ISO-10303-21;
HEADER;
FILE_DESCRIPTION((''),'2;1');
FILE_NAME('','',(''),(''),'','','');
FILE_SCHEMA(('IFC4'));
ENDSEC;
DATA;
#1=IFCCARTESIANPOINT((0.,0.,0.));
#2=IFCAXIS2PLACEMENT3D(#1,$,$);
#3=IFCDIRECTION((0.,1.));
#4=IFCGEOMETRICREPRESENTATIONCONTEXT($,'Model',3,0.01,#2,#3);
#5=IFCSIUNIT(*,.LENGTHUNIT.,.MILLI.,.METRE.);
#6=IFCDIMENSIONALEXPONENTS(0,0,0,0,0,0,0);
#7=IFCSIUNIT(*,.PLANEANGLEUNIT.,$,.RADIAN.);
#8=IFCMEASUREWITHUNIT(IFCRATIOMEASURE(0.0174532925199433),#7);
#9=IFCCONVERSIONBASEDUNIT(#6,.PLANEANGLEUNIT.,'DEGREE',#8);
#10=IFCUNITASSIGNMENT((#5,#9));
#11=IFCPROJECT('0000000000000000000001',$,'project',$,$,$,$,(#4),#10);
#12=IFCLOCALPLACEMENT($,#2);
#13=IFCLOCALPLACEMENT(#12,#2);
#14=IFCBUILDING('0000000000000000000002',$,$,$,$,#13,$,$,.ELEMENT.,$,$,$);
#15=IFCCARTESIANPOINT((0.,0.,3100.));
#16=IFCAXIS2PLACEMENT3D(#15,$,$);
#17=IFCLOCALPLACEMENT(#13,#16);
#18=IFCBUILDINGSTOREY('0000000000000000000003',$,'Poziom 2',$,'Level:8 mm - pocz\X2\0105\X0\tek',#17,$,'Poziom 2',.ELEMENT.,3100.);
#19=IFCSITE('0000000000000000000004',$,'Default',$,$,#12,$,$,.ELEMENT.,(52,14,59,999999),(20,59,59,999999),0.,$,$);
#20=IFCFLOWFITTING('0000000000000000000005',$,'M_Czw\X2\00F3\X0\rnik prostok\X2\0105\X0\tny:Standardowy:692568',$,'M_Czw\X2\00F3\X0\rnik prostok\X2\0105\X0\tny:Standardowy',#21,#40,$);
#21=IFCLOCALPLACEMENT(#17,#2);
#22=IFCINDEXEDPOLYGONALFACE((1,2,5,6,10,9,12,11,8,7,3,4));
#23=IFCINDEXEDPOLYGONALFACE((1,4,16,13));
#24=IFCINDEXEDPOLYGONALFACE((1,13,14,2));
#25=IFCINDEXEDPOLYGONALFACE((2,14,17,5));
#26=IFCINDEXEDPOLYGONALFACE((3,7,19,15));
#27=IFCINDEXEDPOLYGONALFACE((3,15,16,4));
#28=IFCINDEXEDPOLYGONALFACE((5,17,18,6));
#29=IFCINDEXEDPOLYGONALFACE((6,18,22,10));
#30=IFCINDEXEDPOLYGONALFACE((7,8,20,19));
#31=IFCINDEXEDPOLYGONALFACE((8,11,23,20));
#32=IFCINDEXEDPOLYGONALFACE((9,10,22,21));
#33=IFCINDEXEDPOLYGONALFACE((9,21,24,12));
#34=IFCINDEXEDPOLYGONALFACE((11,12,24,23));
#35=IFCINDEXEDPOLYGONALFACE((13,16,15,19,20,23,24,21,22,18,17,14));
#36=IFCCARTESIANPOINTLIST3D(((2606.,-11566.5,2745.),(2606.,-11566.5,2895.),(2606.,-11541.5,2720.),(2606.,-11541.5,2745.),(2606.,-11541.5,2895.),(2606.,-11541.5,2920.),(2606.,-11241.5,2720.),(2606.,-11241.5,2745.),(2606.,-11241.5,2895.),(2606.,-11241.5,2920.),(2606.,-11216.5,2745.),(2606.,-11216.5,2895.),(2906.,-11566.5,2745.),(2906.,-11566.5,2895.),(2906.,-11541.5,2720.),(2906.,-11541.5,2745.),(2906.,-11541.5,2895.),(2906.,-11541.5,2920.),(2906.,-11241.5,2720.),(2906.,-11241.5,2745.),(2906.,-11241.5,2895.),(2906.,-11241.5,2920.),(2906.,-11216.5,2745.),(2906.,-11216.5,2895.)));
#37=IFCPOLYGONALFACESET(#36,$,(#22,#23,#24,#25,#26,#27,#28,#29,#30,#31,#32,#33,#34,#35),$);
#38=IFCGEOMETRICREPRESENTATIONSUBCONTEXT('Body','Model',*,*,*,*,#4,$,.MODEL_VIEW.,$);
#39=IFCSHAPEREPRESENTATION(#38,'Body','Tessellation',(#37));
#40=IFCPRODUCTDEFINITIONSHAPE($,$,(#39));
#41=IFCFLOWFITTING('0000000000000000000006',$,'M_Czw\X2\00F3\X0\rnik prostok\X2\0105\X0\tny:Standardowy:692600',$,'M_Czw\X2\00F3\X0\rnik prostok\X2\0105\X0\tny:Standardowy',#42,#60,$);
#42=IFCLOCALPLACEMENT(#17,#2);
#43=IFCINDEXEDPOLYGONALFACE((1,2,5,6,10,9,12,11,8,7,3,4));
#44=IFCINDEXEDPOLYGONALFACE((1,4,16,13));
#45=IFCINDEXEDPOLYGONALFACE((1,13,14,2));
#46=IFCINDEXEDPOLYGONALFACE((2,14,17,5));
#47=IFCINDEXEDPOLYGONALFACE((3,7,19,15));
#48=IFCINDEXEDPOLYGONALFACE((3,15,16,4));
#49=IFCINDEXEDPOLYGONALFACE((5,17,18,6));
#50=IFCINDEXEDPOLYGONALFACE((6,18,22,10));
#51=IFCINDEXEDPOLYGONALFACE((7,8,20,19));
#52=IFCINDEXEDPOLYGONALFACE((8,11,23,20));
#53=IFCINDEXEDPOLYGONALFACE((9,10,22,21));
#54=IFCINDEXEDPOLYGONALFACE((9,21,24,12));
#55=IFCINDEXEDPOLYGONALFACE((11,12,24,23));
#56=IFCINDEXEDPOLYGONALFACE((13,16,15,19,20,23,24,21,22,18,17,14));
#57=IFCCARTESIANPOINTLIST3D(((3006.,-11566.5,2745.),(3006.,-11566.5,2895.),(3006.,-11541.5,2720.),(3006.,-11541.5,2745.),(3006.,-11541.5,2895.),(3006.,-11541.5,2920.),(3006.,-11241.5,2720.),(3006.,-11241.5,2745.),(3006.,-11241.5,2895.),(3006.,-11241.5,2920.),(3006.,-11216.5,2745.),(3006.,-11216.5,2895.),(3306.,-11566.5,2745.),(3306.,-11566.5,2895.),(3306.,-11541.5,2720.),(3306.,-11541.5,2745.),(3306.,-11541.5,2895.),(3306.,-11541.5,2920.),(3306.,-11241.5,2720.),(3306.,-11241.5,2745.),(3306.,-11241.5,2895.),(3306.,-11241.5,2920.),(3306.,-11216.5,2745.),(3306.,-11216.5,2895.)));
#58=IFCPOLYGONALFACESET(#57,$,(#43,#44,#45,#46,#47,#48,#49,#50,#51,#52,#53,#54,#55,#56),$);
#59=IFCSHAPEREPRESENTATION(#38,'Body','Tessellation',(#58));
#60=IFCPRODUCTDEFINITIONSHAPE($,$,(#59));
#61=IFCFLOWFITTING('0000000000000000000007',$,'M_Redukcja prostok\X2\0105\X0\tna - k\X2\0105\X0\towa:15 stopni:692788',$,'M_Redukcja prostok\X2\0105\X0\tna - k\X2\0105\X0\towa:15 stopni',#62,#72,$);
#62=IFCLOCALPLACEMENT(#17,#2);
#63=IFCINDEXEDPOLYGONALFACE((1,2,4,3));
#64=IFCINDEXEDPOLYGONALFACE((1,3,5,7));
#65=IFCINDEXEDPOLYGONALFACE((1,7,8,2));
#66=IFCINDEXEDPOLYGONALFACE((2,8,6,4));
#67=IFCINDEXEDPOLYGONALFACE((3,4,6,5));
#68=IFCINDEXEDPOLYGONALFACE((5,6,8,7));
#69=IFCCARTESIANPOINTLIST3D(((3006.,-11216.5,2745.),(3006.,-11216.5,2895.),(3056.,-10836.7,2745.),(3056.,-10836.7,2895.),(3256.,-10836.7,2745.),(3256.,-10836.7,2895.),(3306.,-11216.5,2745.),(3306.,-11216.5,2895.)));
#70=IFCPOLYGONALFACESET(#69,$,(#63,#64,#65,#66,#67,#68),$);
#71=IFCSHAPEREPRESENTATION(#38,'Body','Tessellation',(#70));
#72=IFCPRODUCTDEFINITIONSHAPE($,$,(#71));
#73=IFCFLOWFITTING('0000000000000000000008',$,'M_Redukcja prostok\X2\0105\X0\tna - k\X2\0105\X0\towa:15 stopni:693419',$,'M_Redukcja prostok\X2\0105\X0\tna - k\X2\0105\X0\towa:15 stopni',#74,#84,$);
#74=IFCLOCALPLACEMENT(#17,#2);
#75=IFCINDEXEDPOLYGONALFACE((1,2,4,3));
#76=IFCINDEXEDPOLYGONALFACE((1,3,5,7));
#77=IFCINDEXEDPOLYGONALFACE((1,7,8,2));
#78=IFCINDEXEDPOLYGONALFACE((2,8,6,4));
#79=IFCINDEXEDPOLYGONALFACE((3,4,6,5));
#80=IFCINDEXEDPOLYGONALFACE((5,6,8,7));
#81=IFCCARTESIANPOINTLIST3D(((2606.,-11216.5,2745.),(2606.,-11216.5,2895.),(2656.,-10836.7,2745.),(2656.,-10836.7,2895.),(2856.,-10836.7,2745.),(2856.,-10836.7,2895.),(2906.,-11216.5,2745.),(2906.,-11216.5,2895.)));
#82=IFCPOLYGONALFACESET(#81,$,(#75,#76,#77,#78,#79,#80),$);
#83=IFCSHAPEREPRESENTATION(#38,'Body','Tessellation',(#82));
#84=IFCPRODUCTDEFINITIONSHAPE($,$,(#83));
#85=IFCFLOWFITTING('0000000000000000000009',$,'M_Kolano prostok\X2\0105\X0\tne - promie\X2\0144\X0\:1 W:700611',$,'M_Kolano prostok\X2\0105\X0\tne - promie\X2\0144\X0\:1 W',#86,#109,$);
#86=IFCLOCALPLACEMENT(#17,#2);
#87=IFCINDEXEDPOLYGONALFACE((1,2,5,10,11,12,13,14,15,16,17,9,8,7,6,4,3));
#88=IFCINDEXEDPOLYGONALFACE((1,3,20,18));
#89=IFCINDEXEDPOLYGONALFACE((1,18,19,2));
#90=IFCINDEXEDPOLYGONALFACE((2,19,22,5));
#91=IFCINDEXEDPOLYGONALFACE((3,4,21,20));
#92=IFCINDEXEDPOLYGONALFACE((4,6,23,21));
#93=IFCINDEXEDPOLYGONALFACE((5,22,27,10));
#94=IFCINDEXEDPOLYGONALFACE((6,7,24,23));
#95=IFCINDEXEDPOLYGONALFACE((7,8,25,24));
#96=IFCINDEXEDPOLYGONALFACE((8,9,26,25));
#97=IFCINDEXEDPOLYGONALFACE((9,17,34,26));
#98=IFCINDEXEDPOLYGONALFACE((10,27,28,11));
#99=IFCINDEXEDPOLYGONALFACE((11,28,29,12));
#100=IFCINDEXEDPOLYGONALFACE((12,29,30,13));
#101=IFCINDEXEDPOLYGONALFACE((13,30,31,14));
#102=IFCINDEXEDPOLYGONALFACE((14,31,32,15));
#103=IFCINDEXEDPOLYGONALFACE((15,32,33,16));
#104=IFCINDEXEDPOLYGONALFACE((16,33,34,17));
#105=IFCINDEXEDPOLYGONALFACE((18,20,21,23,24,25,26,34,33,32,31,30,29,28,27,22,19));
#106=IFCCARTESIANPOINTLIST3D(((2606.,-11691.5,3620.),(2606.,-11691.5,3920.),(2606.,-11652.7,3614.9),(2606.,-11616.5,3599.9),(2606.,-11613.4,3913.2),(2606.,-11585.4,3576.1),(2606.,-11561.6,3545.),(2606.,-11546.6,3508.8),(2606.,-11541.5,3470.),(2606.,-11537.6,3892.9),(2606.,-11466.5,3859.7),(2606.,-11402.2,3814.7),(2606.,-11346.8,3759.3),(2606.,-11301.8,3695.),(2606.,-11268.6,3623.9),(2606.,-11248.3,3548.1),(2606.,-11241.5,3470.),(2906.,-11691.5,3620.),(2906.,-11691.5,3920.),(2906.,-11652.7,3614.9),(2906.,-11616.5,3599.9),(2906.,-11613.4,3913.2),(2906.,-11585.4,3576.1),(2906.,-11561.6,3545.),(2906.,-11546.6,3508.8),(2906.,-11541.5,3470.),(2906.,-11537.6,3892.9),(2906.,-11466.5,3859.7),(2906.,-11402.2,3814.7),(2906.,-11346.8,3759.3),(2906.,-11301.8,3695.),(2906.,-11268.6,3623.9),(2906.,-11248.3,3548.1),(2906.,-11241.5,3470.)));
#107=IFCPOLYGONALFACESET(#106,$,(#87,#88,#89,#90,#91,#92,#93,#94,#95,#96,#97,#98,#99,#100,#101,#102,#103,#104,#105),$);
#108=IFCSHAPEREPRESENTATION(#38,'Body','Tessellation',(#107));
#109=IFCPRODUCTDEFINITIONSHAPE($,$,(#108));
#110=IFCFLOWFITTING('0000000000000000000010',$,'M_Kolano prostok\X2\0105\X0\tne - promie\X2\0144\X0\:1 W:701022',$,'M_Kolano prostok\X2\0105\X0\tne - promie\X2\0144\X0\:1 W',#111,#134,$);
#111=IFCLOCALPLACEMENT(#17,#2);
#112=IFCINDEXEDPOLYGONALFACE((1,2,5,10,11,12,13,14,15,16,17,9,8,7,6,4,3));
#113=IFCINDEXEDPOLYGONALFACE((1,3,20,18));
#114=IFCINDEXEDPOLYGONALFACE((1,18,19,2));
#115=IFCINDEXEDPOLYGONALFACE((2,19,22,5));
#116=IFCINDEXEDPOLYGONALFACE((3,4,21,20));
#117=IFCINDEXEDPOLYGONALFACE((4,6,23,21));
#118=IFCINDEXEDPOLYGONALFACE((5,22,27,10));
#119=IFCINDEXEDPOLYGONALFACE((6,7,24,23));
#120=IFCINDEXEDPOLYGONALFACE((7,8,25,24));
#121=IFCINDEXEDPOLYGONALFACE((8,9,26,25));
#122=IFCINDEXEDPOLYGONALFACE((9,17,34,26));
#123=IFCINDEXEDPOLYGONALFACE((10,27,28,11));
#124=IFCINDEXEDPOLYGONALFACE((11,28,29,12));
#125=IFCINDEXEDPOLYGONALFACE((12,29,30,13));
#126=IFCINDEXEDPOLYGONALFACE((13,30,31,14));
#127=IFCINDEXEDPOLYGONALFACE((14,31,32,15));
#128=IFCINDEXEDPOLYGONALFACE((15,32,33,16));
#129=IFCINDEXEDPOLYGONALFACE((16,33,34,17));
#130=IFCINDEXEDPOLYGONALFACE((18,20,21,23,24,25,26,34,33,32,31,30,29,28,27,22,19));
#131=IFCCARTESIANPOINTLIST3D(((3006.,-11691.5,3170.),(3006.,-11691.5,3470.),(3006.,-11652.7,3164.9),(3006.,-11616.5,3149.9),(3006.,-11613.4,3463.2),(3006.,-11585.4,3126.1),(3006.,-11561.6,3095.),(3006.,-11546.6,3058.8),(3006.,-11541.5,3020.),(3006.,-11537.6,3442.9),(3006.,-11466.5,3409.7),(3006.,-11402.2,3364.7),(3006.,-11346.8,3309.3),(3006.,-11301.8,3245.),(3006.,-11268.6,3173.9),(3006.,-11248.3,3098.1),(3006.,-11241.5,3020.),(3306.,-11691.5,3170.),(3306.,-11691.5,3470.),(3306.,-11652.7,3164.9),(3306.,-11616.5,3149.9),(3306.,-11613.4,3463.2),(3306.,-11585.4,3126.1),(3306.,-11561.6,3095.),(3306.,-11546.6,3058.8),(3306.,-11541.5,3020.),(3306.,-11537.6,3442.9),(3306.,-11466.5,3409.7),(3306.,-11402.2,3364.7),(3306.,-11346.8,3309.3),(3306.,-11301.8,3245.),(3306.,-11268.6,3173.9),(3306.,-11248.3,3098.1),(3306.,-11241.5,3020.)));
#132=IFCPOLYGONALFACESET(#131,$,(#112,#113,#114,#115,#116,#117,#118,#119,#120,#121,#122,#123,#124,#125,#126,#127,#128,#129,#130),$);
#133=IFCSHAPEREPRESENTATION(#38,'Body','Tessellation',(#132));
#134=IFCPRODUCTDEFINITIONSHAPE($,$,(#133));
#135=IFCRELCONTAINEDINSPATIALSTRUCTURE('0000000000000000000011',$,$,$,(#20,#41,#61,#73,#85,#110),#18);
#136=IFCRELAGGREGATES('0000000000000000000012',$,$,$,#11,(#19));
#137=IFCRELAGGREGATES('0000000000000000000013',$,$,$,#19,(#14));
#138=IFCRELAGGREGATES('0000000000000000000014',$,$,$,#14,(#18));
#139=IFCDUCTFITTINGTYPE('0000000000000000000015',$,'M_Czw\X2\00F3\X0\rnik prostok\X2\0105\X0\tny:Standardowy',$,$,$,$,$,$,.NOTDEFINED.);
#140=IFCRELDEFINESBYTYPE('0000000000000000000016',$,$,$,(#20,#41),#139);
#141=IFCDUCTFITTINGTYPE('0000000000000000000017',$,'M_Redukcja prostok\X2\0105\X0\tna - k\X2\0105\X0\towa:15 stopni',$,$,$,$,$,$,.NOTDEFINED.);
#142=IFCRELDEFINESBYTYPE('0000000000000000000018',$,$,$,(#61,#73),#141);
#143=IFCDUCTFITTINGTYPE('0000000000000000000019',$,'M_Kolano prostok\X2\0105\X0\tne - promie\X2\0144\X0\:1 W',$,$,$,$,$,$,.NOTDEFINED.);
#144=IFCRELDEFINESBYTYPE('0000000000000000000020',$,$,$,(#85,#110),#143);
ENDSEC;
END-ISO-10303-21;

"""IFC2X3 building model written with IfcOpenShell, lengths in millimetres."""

from ifc_helpers import new_model, entity, si_unit, converted_unit, direction, frame, frame_2d, origin, place, context, subcontext, project, spatial, polyline, circle_curve, parameter, trimmed, segment, composite_curve, outline, extrude, source, transform, mapped, type_object, type_shapes, element, save


model = new_model("IFC2X3")

# Units and contexts
model_context = context("Model", 3, precision=0.01, world=origin(), true_north=direction((0.0, 1.0)))
body_context = subcontext(model_context, "Body", "Model", "MODEL_VIEW")
ifc_project = project(units=[si_unit("LENGTHUNIT", "METRE", prefix="MILLI"), converted_unit("PLANEANGLEUNIT", "DEGREE", entity("IfcRatioMeasure", 0.0174532925199433), si_unit("PLANEANGLEUNIT", "RADIAN"), dimensions=[0, 0, 0, 0, 0, 0, 0])], contexts=[model_context])

# Site, building, storey
site_placement = place(None, origin())
site = spatial("IfcSite", under=ifc_project, at=site_placement, Name="Default", CompositionType="ELEMENT", RefLatitude=(52, 14, 59, 999999), RefLongitude=(20, 59, 59, 999999), RefElevation=0.0)
building_placement = place(site_placement, origin())
building = spatial("IfcBuilding", under=site, at=building_placement, CompositionType="ELEMENT")
storey_placement = place(building_placement, frame((0.0, 0.0, 3100.0)))
storey = spatial("IfcBuildingStorey", under=building, at=storey_placement, Name="Poziom 2", ObjectType="Level:8 mm - początek", LongName="Poziom 2", CompositionType="ELEMENT", Elevation=3100.0)

# Flow fittings
duct_fitting_type_1 = type_object("IfcDuctFittingType", Name="M_Czwórnik prostokątny:Standardowy", PredefinedType="NOTDEFINED")
shared_shape_1 = source(origin(), body_context, "Body", "SweptSolid", [
    extrude(outline(polyline([(-175.0, 75.0), (-175.0, -75.0), (-150.0, -75.0), (-150.0, -100.0), (150.0, -100.0), (150.0, -75.0), (175.0, -75.0), (175.0, 75.0), (150.0, 75.0), (150.0, 100.0), (-150.0, 100.0), (-150.0, 75.0), (-175.0, 75.0)])), frame((0.0, 0.0, -150.0), z_axis=(0.0, 0.0, -1.0), x_axis=(0.0, 1.0, 0.0)), (0.0, 0.0, -1.0), 300.0),
])
type_shapes(duct_fitting_type_1, [shared_shape_1])
for number, where, z_axis, x_axis, name in (
    (1, (2756.0, -11391.5, 2820.0), (1.0, 0.0, 0.0), (0.0, 0.0, 1.0), "M_Czwórnik prostokątny:Standardowy:692568"),
    (2, (3156.0, -11391.5, 2820.0), (1.0, 0.0, 0.0), (0.0, 0.0, 1.0), "M_Czwórnik prostokątny:Standardowy:692600"),
):
    element("IfcFlowFitting", number, at=place(storey_placement, frame(where, z_axis=z_axis, x_axis=x_axis)), inside=storey, type_object=duct_fitting_type_1, Name=name, ObjectType="M_Czwórnik prostokątny:Standardowy", context=body_context, shape_type="MappedRepresentation", body=[
        mapped(shared_shape_1, transform((0.0, 0.0, 0.0), scale=1.0)),
    ])
duct_fitting_type_2 = type_object("IfcDuctFittingType", Name="M_Redukcja prostokątna - kątowa:15 stopni", PredefinedType="NOTDEFINED")
shared_shape_2 = source(origin(), body_context, "Body", "SweptSolid", [
    extrude(outline(polyline([(-150.0, -189.9), (150.0, -189.9), (100.0, 189.9), (-100.0, 189.9), (-150.0, -189.9)])), frame((189.9, 0.0, -75.0), z_axis=(0.0, 0.0, 1.0), x_axis=(0.0, -1.0, 0.0)), (0.0, 0.0, 1.0), 150.0),
])
type_shapes(duct_fitting_type_2, [shared_shape_2])
for number, where, z_axis, x_axis, name in (
    (3, (3156.0, -11216.5, 2820.0), (0.0, 0.0, 1.0), (0.0, 1.0, 0.0), "M_Redukcja prostokątna - kątowa:15 stopni:692788"),
    (4, (2756.0, -11216.5, 2820.0), (0.0, 0.0, 1.0), (0.0, 1.0, 0.0), "M_Redukcja prostokątna - kątowa:15 stopni:693419"),
):
    element("IfcFlowFitting", number, at=place(storey_placement, frame(where, z_axis=z_axis, x_axis=x_axis)), inside=storey, type_object=duct_fitting_type_2, Name=name, ObjectType="M_Redukcja prostokątna - kątowa:15 stopni", context=body_context, shape_type="MappedRepresentation", body=[
        mapped(shared_shape_2, transform((0.0, 0.0, 0.0), scale=1.0)),
    ])
duct_fitting_type_3 = type_object("IfcDuctFittingType", Name="M_Kolano prostokątne - promień:1 W", PredefinedType="NOTDEFINED")
shared_shape_3 = source(origin(), body_context, "Body", "SweptSolid", [
    extrude(outline(composite_curve([segment(polyline([(-300.0, -150.0), (0.0, -150.0)]), True, "CONTINUOUS"), segment(trimmed(circle_curve(frame_2d((150.0, -150.0), x_axis=(0.0, 1.0)), 150.0), [parameter(0.0)], [parameter(90.0)], True, "PARAMETER"), False, "CONTINUOUS"), segment(polyline([(150.0, 0.0), (150.0, 300.0)]), True, "CONTINUOUS"), segment(trimmed(circle_curve(frame_2d((150.0, -150.0), x_axis=(0.0, 1.0)), 450.0), [parameter(0.0)], [parameter(90.0)], True, "PARAMETER"), True, "CONTINUOUS")], self_intersect=False)), frame((-150.0, 150.0, -150.0), z_axis=(0.0, 0.0, 1.0), x_axis=(-1.0, 0.0, 0.0)), (0.0, 0.0, 1.0), 300.0),
])
type_shapes(duct_fitting_type_3, [shared_shape_3])
for number, where, z_axis, x_axis, name in (
    (5, (2756.0, -11391.5, 3770.0), (1.0, 0.0, 0.0), (0.0, 0.0, 1.0), "M_Kolano prostokątne - promień:1 W:700611"),
    (6, (3156.0, -11391.5, 3320.0), (1.0, 0.0, 0.0), (0.0, 0.0, 1.0), "M_Kolano prostokątne - promień:1 W:701022"),
):
    element("IfcFlowFitting", number, at=place(storey_placement, frame(where, z_axis=z_axis, x_axis=x_axis)), inside=storey, type_object=duct_fitting_type_3, Name=name, ObjectType="M_Kolano prostokątne - promień:1 W", context=body_context, shape_type="MappedRepresentation", body=[
        mapped(shared_shape_3, transform((0.0, 0.0, 0.0), scale=1.0)),
    ])

save(model, "model.ifc")
